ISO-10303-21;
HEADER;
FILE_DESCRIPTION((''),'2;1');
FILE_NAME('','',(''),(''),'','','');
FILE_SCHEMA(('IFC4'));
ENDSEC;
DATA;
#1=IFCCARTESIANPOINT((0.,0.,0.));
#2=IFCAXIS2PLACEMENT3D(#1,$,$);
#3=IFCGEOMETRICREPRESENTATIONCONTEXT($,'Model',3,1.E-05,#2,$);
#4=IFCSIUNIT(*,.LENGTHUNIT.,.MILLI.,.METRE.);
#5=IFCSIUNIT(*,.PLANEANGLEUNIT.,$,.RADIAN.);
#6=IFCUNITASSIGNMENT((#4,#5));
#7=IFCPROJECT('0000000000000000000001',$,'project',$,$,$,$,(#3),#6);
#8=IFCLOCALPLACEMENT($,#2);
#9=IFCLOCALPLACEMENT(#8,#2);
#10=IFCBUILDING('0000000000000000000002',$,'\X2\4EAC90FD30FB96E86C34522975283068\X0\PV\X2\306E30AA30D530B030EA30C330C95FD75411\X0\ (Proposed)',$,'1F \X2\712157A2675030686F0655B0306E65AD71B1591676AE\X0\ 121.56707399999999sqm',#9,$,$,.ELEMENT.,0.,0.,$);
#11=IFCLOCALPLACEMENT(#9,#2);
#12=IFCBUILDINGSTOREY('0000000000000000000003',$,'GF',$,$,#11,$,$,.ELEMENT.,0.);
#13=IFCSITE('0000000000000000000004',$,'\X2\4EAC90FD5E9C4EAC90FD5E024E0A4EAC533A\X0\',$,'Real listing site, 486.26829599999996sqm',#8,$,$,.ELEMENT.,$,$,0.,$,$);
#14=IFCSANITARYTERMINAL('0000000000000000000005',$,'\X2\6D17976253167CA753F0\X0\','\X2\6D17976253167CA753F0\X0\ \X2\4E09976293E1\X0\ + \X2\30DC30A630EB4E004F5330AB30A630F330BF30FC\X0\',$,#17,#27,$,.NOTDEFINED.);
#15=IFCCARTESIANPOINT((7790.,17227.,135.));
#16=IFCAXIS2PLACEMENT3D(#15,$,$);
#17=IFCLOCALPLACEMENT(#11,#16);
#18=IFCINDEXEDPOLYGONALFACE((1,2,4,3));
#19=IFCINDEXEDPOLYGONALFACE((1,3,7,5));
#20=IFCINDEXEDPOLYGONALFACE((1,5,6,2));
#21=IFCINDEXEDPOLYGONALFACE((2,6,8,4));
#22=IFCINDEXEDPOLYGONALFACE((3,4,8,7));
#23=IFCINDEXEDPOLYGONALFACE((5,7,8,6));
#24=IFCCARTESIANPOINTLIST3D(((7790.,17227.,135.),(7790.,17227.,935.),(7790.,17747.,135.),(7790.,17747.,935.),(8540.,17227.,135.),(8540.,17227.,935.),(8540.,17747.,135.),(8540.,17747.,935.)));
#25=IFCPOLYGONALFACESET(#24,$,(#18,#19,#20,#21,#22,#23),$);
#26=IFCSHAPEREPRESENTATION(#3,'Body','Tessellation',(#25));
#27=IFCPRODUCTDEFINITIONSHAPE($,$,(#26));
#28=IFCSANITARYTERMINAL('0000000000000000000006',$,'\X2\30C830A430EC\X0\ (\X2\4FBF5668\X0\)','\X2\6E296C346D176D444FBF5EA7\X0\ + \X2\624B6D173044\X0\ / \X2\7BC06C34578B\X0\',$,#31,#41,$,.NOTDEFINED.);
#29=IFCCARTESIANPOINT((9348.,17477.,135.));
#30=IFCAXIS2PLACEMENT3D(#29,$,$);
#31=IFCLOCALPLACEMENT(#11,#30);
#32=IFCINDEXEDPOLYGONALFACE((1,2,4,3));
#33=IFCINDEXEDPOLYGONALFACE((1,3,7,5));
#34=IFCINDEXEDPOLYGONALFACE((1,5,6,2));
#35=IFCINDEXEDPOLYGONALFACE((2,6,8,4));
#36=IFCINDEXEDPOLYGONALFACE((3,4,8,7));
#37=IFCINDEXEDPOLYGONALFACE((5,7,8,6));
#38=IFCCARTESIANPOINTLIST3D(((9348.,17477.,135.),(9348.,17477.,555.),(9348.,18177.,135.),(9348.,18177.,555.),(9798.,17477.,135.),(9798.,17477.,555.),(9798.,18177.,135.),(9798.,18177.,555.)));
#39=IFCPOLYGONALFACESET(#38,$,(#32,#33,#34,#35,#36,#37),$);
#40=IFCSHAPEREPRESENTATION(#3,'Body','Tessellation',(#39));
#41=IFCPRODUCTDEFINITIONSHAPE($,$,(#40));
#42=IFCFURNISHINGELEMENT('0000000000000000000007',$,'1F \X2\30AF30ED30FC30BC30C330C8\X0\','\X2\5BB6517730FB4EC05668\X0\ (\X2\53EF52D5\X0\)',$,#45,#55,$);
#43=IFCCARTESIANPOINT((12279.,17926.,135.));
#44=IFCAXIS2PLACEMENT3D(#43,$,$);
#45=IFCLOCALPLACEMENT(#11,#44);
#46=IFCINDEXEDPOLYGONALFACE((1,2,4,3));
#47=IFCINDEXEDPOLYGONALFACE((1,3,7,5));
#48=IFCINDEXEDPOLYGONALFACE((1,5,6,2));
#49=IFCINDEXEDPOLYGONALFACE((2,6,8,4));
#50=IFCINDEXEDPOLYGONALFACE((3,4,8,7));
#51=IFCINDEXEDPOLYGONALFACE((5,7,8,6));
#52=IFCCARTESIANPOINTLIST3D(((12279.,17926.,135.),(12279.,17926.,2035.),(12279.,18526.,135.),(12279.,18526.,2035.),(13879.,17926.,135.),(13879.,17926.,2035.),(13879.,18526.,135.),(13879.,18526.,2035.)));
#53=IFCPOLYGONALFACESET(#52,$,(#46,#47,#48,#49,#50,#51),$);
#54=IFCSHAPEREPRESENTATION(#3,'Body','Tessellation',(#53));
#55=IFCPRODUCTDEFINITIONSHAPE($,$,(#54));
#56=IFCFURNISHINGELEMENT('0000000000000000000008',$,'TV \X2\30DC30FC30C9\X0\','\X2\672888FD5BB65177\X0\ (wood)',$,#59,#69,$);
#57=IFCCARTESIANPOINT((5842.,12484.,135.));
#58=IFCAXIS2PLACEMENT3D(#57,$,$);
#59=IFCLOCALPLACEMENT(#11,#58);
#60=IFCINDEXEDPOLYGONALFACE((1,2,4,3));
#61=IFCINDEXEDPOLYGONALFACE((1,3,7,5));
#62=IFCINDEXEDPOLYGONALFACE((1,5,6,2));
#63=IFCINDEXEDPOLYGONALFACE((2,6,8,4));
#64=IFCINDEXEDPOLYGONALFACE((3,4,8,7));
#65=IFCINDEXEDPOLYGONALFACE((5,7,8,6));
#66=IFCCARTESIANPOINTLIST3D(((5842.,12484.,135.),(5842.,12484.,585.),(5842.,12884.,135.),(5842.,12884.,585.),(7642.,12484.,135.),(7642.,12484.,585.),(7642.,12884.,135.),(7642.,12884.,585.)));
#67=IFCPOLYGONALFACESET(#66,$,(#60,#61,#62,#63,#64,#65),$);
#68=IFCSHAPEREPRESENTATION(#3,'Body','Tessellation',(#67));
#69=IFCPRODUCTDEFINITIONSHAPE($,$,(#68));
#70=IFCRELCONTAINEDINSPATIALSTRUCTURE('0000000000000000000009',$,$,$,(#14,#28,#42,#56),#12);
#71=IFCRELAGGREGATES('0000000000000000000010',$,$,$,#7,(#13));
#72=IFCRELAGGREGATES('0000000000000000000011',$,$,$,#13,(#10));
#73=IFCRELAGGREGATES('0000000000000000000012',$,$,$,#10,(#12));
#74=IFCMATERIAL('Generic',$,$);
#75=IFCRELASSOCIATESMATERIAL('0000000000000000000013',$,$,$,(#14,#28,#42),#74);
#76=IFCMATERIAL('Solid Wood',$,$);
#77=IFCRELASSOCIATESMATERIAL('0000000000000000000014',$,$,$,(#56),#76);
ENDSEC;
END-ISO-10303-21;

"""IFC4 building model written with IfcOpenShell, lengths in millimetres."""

from ifc_helpers import new_model, si_unit, frame, frame_2d, origin, place, context, project, spatial, rectangle, extrude, material, element, save


model = new_model("IFC4")

# Units and contexts
model_context = context("Model", 3, precision=1e-05, world=origin())
ifc_project = project(units=[si_unit("LENGTHUNIT", "METRE", prefix="MILLI"), si_unit("PLANEANGLEUNIT", "RADIAN")], contexts=[model_context])

# Site, building, storey
site_placement = place(None, origin())
site = spatial("IfcSite", under=ifc_project, at=site_placement, Name="京都府京都市上京区", ObjectType="Real listing site, 486.26829599999996sqm", CompositionType="ELEMENT", RefElevation=0.0)
building_placement = place(site_placement, origin())
building = spatial("IfcBuilding", under=site, at=building_placement, Name="京都・雨水利用とPVのオフグリッド志向 (Proposed)", ObjectType="1F 無垢材と漆喰の断熱外皮 121.56707399999999sqm", CompositionType="ELEMENT", ElevationOfRefHeight=0.0, ElevationOfTerrain=0.0)
storey_placement = place(building_placement, origin())
storey = spatial("IfcBuildingStorey", under=building, at=storey_placement, Name="GF", CompositionType="ELEMENT", Elevation=0.0)

# Shared definitions
ifc_material_1 = material(Name="Solid Wood")

# Sanitary terminals
ifc_material_2 = material(Name="Generic")
sanitary_terminal_1_placement = place(storey_placement, frame((7790.0, 17227.0, 135.0)))
element("IfcSanitaryTerminal", 1, at=sanitary_terminal_1_placement, inside=storey, material=ifc_material_2, Name="洗面化粧台", Description="洗面化粧台 三面鏡 + ボウル一体カウンター", PredefinedType="NOTDEFINED", context=model_context, shape_type="SweptSolid", body=[
    extrude(rectangle(XDim=750.0, YDim=520.0, at=frame_2d((375.0, 260.0))), frame((7790.0, 17227.0, 135.0)), (0.0, 0.0, 1.0), 800.0),
])
sanitary_terminal_2_placement = place(storey_placement, frame((9348.0, 17477.0, 135.0)))
element("IfcSanitaryTerminal", 2, at=sanitary_terminal_2_placement, inside=storey, material=ifc_material_2, Name="トイレ (便器)", Description="温水洗浄便座 + 手洗い / 節水型", PredefinedType="NOTDEFINED", context=model_context, shape_type="SweptSolid", body=[
    extrude(rectangle(XDim=450.0, YDim=700.0, at=frame_2d((225.0, 350.0))), frame((9348.0, 17477.0, 135.0)), (0.0, 0.0, 1.0), 420.0),
])

# Furnishing elements
furnishing_1_placement = place(storey_placement, frame((12279.0, 17926.0, 135.0)))
element("IfcFurnishingElement", 3, at=furnishing_1_placement, inside=storey, material=ifc_material_2, Name="1F クローゼット", Description="家具・什器 (可動)", context=model_context, shape_type="SweptSolid", body=[
    extrude(rectangle(XDim=1600.0, YDim=600.0, at=frame_2d((800.0, 300.0))), frame((12279.0, 17926.0, 135.0)), (0.0, 0.0, 1.0), 1900.0),
])
furnishing_2_placement = place(storey_placement, frame((5842.0, 12484.0, 135.0)))
element("IfcFurnishingElement", 4, at=furnishing_2_placement, inside=storey, material=ifc_material_1, Name="TV ボード", Description="木製家具 (wood)", context=model_context, shape_type="SweptSolid", body=[
    extrude(rectangle(XDim=1800.0, YDim=400.0, at=frame_2d((900.0, 200.0))), frame((5842.0, 12484.0, 135.0)), (0.0, 0.0, 1.0), 450.0),
])

save(model, "model.ifc")
